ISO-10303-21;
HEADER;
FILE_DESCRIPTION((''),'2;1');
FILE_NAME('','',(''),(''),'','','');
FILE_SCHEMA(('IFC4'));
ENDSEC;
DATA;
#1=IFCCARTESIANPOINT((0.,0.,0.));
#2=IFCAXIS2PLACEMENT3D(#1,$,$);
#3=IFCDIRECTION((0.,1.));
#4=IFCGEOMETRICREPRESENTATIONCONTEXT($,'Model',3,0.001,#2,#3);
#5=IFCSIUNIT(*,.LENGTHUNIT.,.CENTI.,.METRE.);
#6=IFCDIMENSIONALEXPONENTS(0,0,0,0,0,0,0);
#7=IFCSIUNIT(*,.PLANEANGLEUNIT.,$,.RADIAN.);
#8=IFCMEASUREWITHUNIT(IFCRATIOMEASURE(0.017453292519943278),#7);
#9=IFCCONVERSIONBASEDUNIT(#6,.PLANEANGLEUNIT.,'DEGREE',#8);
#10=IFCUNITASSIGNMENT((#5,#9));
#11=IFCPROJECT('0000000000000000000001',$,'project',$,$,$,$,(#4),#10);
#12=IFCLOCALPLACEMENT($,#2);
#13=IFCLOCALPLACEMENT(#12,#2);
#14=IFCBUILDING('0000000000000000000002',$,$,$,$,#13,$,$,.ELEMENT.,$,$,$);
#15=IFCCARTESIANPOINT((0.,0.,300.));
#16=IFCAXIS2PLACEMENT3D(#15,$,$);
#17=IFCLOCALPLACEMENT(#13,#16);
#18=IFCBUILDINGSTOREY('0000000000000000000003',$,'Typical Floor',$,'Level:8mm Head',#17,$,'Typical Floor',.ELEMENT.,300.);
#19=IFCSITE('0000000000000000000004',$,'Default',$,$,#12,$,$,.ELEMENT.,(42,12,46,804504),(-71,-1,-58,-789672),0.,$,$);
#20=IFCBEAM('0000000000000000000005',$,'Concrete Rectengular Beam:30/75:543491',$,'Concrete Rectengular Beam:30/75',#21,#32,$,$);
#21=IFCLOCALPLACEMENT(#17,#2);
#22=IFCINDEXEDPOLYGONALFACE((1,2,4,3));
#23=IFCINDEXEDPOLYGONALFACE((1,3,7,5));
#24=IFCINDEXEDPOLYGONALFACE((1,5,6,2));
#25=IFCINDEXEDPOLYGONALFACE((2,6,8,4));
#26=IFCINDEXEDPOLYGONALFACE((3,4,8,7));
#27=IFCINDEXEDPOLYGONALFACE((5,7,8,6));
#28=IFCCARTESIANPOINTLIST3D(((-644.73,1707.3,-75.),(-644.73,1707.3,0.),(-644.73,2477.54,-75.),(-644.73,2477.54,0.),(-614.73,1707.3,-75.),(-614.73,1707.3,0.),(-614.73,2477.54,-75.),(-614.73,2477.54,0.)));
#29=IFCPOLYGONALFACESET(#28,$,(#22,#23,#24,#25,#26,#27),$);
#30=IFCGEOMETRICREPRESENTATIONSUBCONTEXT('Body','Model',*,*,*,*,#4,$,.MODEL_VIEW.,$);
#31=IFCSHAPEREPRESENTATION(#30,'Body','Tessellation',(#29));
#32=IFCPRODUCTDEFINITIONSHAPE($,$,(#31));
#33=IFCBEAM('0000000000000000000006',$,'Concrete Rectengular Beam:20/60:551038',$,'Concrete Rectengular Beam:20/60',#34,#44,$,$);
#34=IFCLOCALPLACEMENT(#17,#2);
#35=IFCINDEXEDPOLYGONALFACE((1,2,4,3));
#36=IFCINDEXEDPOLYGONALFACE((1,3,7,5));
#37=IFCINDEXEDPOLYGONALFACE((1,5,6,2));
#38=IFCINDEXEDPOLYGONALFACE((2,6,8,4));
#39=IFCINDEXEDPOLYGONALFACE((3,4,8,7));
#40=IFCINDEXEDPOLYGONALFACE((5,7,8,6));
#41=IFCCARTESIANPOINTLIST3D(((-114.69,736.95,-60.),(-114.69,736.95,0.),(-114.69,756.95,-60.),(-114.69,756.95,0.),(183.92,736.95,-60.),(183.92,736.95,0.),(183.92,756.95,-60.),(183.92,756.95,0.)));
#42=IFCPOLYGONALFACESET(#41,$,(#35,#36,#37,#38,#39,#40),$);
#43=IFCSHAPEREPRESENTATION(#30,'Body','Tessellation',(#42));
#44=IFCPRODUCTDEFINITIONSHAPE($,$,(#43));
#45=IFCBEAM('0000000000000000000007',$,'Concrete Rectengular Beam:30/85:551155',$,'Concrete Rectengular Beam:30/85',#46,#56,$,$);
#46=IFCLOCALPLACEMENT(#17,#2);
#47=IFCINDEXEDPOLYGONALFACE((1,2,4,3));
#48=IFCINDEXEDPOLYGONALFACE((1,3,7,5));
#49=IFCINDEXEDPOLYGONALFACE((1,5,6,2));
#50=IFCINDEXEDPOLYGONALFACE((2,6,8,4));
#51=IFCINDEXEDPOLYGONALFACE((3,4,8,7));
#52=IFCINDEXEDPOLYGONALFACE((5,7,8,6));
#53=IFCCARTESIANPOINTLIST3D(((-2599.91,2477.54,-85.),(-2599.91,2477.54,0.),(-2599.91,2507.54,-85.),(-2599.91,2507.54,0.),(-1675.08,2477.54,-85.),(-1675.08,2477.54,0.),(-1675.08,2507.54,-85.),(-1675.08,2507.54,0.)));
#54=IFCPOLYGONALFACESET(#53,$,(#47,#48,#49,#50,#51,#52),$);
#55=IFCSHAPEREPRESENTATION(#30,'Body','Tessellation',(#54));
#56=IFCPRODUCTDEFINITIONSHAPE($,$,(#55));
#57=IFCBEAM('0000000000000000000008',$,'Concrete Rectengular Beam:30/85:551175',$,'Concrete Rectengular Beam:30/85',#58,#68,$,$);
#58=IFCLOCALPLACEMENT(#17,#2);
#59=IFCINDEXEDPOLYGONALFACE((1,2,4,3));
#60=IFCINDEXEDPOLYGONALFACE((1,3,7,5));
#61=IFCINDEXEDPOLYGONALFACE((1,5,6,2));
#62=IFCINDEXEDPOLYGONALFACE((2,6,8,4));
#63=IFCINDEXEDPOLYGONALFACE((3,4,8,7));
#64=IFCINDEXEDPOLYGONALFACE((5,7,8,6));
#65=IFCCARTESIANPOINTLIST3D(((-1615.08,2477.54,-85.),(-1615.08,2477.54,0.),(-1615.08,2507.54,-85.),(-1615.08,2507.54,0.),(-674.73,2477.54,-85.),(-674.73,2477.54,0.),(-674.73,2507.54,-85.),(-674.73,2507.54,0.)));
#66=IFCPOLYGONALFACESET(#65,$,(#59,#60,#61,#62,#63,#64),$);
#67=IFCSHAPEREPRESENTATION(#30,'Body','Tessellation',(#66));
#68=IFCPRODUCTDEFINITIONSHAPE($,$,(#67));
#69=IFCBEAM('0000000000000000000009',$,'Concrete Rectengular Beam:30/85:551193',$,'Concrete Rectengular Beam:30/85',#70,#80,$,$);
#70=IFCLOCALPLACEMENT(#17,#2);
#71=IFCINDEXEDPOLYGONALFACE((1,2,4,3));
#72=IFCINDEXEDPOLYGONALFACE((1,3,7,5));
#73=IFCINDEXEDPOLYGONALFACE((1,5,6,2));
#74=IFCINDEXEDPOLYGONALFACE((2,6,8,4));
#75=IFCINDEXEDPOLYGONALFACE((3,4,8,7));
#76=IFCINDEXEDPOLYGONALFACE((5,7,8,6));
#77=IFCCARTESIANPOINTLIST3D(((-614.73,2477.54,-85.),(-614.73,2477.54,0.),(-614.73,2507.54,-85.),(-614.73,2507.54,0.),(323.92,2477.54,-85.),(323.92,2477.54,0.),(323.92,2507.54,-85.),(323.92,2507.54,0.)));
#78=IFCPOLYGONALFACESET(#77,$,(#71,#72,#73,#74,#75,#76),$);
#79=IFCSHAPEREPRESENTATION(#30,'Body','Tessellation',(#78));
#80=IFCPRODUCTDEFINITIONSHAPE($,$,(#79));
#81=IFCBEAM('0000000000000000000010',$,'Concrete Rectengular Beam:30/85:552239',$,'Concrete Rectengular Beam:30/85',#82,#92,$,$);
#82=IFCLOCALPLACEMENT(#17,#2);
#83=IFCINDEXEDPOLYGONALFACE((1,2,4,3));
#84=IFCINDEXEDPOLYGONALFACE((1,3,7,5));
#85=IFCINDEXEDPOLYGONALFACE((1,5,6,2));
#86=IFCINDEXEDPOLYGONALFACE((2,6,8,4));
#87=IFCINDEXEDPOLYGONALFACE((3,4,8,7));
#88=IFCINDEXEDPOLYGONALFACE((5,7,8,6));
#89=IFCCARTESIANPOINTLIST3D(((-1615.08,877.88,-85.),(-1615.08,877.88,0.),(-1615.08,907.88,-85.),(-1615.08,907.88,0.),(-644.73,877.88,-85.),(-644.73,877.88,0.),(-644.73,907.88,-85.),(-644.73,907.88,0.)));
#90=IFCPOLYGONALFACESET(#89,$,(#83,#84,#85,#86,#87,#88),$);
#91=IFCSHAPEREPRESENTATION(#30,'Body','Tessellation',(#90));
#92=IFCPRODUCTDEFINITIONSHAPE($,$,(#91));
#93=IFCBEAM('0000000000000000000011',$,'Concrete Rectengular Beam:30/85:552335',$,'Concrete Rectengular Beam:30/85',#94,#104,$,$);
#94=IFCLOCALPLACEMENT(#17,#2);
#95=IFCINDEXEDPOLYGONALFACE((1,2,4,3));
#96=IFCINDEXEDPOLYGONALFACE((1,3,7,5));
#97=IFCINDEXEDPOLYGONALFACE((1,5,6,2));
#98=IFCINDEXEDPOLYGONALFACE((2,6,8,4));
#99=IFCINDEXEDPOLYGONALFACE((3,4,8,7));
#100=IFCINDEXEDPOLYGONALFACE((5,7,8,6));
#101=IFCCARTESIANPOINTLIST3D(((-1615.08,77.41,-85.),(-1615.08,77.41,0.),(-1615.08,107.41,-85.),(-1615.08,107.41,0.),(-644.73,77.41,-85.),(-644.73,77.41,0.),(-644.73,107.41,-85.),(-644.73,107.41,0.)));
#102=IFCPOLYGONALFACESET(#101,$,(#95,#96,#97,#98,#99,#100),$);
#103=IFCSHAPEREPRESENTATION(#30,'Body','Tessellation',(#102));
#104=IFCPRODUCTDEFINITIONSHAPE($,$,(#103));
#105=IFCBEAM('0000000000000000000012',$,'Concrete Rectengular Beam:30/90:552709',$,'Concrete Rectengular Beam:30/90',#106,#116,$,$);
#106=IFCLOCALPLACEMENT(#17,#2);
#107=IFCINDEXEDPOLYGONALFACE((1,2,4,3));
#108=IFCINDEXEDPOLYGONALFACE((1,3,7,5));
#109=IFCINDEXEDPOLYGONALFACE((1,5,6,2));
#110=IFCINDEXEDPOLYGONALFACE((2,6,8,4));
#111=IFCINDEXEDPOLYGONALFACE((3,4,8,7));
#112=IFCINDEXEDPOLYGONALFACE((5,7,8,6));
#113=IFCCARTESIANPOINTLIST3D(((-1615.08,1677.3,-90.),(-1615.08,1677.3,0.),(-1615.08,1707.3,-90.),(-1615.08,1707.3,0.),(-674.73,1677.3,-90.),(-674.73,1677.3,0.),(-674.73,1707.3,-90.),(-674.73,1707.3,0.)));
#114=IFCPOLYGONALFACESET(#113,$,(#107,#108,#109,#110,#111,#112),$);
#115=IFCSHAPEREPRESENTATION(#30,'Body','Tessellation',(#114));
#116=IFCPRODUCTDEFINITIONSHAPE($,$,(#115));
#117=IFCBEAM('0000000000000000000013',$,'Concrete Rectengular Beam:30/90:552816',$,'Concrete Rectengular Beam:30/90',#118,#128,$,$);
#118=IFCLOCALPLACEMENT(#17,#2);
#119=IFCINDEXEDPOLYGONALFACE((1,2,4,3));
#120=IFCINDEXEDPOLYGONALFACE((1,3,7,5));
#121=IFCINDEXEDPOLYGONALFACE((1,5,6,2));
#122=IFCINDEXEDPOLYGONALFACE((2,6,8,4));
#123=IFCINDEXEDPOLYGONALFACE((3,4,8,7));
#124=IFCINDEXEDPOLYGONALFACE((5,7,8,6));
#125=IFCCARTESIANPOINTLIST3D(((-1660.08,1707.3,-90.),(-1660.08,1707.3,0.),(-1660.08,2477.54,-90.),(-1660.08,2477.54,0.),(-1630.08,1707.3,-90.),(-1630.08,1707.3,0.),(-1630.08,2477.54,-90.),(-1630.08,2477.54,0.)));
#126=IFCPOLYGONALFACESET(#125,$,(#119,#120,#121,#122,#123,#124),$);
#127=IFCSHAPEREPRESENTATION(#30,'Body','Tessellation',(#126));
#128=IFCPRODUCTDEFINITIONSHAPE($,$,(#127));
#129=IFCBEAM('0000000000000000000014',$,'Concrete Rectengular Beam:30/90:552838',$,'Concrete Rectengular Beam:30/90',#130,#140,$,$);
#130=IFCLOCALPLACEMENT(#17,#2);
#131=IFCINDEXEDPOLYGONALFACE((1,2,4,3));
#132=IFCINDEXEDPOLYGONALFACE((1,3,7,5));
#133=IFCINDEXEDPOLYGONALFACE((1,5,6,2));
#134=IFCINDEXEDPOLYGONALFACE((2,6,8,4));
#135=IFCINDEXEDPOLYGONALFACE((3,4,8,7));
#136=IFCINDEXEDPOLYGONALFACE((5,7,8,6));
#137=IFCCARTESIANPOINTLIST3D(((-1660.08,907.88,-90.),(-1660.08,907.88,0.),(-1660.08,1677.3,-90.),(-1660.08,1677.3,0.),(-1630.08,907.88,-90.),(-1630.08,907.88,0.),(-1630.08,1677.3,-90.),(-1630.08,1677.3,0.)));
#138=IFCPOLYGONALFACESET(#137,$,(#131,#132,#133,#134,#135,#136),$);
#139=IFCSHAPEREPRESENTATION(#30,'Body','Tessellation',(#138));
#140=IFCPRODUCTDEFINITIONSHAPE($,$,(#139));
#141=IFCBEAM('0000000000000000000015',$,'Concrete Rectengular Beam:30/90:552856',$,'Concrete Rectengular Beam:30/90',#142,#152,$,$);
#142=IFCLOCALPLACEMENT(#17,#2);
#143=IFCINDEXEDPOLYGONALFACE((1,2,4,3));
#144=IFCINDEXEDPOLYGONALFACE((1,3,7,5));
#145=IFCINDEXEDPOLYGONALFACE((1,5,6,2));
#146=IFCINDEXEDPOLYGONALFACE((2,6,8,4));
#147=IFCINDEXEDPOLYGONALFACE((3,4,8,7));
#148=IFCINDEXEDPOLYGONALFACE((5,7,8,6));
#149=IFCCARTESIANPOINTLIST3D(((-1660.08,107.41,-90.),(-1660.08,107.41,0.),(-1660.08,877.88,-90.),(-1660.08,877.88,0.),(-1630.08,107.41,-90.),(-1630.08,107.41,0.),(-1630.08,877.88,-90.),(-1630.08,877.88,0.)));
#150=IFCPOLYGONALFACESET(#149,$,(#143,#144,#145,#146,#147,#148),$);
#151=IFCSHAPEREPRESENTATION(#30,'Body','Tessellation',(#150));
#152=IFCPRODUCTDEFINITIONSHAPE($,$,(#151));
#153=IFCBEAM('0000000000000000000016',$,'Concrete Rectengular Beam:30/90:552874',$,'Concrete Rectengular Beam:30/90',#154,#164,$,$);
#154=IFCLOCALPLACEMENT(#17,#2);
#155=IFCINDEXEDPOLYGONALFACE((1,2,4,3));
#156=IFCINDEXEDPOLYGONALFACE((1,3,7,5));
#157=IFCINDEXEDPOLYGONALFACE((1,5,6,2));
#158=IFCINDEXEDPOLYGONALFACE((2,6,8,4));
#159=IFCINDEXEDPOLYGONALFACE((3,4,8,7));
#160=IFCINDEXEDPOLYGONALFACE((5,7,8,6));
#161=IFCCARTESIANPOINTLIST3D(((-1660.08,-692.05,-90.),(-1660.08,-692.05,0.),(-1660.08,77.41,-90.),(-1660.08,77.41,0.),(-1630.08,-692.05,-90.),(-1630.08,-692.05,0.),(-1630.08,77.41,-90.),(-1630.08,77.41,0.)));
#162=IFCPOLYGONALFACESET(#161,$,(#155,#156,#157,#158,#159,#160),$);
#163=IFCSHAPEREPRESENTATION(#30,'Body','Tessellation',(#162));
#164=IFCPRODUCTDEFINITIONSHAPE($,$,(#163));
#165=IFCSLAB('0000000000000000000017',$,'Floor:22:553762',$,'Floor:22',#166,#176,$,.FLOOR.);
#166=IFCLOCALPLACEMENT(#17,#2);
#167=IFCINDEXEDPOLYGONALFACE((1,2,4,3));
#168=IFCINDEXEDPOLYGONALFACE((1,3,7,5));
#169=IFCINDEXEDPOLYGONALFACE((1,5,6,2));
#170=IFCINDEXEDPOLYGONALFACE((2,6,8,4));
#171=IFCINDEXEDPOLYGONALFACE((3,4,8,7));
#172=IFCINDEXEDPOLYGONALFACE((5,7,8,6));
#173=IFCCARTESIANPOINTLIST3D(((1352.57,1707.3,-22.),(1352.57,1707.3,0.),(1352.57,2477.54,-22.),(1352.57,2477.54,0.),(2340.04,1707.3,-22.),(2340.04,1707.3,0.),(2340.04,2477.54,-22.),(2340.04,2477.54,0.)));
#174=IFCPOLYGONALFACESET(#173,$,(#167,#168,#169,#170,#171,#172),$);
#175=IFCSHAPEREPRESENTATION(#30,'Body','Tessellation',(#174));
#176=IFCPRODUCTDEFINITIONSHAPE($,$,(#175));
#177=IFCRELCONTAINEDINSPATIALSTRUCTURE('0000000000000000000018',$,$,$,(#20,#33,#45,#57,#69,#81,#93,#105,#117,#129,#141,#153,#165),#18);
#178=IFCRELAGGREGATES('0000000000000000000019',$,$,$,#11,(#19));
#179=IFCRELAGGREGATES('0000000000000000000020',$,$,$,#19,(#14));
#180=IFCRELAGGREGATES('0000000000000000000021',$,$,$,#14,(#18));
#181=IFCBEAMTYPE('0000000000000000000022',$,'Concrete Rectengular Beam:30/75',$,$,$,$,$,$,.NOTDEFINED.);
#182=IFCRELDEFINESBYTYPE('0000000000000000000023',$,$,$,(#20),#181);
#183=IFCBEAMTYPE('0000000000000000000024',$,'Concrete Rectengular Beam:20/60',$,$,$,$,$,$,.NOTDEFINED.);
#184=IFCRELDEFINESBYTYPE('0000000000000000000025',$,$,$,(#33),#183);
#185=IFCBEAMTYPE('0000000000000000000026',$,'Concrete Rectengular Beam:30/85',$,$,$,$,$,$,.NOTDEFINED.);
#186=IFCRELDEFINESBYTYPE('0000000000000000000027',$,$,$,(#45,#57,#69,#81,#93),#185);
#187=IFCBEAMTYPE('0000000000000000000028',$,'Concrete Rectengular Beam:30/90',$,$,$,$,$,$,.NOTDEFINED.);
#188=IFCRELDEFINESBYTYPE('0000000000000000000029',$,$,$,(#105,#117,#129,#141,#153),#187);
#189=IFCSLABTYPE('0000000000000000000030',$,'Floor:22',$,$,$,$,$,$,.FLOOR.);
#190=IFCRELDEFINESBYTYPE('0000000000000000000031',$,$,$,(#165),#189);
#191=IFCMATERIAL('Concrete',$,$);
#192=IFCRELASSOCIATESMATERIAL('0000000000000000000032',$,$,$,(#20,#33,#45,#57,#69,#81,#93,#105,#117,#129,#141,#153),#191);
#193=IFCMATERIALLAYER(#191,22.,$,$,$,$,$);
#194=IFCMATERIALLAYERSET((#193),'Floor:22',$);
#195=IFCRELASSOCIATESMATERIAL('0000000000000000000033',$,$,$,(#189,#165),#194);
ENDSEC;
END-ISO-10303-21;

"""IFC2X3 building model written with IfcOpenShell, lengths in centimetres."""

from ifc_helpers import new_model, entity, si_unit, converted_unit, direction, frame, frame_2d, origin, origin_2d_with_axis, place, context, subcontext, project, spatial, rectangle, extrude, material, layer, layer_set, layer_usage, type_object, element, save


model = new_model("IFC2X3")

# Units and contexts
model_context = context("Model", 3, precision=0.001, world=origin(), true_north=direction((0.0, 1.0)))
body_context = subcontext(model_context, "Body", "Model", "MODEL_VIEW")
ifc_project = project(units=[si_unit("LENGTHUNIT", "METRE", prefix="CENTI"), converted_unit("PLANEANGLEUNIT", "DEGREE", entity("IfcRatioMeasure", 0.017453292519943278), si_unit("PLANEANGLEUNIT", "RADIAN"), dimensions=[0, 0, 0, 0, 0, 0, 0])], contexts=[model_context])

# Site, building, storey
site_placement = place(None, origin())
site = spatial("IfcSite", under=ifc_project, at=site_placement, Name="Default", CompositionType="ELEMENT", RefLatitude=(42, 12, 46, 804504), RefLongitude=(-71, -1, -58, -789672), RefElevation=0.0)
building_placement = place(site_placement, origin())
building = spatial("IfcBuilding", under=site, at=building_placement, CompositionType="ELEMENT")
storey_placement = place(building_placement, frame((0.0, 0.0, 300.0)))
storey = spatial("IfcBuildingStorey", under=building, at=storey_placement, Name="Typical Floor", ObjectType="Level:8mm Head", LongName="Typical Floor", CompositionType="ELEMENT", Elevation=300.0)

# Beams
ifc_material = material(Name="Concrete")
beam_type_1 = type_object("IfcBeamType", Name="Concrete Rectengular Beam:30/75", PredefinedType="NOTDEFINED")
beam_1_placement = place(storey_placement, frame((-629.73, 2492.54, 0.0), z_axis=(0.0, 0.0, 1.0), x_axis=(0.0, -1.0, 0.0)))
element("IfcBeam", 1, at=beam_1_placement, inside=storey, type_object=beam_type_1, material=ifc_material, Name="Concrete Rectengular Beam:30/75:543491", ObjectType="Concrete Rectengular Beam:30/75", context=body_context, shape_type="SweptSolid", body=[
    extrude(rectangle(XDim=75.0, YDim=30.0, at=frame_2d((0.0, 0.0), x_axis=(1.0, 0.0))), frame((15.0, 0.0, -37.5), z_axis=(1.0, 0.0, 0.0), x_axis=(0.0, 0.0, -1.0)), (0.0, 0.0, 1.0), 770.24),
])
beam_type_2 = type_object("IfcBeamType", Name="Concrete Rectengular Beam:20/60", PredefinedType="NOTDEFINED")
beam_2_placement = place(storey_placement, frame((-124.69, 746.95, 0.0)))
element("IfcBeam", 2, at=beam_2_placement, inside=storey, type_object=beam_type_2, material=ifc_material, Name="Concrete Rectengular Beam:20/60:551038", ObjectType="Concrete Rectengular Beam:20/60", context=body_context, shape_type="SweptSolid", body=[
    extrude(rectangle(XDim=60.0, YDim=20.0, at=frame_2d((0.0, 0.0), x_axis=(1.0, 0.0))), frame((10.0, 0.0, -30.0), z_axis=(1.0, 0.0, 0.0), x_axis=(0.0, 0.0, -1.0)), (0.0, 0.0, 1.0), 298.61),
])
beam_type_3 = type_object("IfcBeamType", Name="Concrete Rectengular Beam:30/85", PredefinedType="NOTDEFINED")
beam_3_placement = place(storey_placement, frame((-2629.91, 2492.54, 0.0)))
element("IfcBeam", 3, at=beam_3_placement, inside=storey, type_object=beam_type_3, material=ifc_material, Name="Concrete Rectengular Beam:30/85:551155", ObjectType="Concrete Rectengular Beam:30/85", context=body_context, shape_type="SweptSolid", body=[
    extrude(rectangle(XDim=85.0, YDim=30.0, at=frame_2d((0.0, 0.0), x_axis=(1.0, 0.0))), frame((30.0, 0.0, -42.5), z_axis=(1.0, 0.0, 0.0), x_axis=(0.0, 0.0, -1.0)), (0.0, 0.0, 1.0), 924.83),
])
beam_4_placement = place(storey_placement, frame((-1645.08, 2492.54, 0.0)))
element("IfcBeam", 4, at=beam_4_placement, inside=storey, type_object=beam_type_3, material=ifc_material, Name="Concrete Rectengular Beam:30/85:551175", ObjectType="Concrete Rectengular Beam:30/85", context=body_context, shape_type="SweptSolid", body=[
    extrude(rectangle(XDim=85.0, YDim=30.0, at=frame_2d((0.0, 0.0), x_axis=(1.0, 0.0))), frame((30.0, 0.0, -42.5), z_axis=(1.0, 0.0, 0.0), x_axis=(0.0, 0.0, -1.0)), (0.0, 0.0, 1.0), 940.35),
])
beam_5_placement = place(storey_placement, frame((-644.73, 2492.54, 0.0)))
element("IfcBeam", 5, at=beam_5_placement, inside=storey, type_object=beam_type_3, material=ifc_material, Name="Concrete Rectengular Beam:30/85:551193", ObjectType="Concrete Rectengular Beam:30/85", context=body_context, shape_type="SweptSolid", body=[
    extrude(rectangle(XDim=85.0, YDim=30.0, at=frame_2d((0.0, 0.0), x_axis=(1.0, 0.0))), frame((30.0, 0.0, -42.5), z_axis=(1.0, 0.0, 0.0), x_axis=(0.0, 0.0, -1.0)), (0.0, 0.0, 1.0), 938.65),
])
beam_6_placement = place(storey_placement, frame((-1645.08, 892.88, 0.0)))
element("IfcBeam", 6, at=beam_6_placement, inside=storey, type_object=beam_type_3, material=ifc_material, Name="Concrete Rectengular Beam:30/85:552239", ObjectType="Concrete Rectengular Beam:30/85", context=body_context, shape_type="SweptSolid", body=[
    extrude(rectangle(XDim=85.0, YDim=30.0, at=frame_2d((0.0, 0.0), x_axis=(1.0, 0.0))), frame((30.0, 0.0, -42.5), z_axis=(1.0, 0.0, 0.0), x_axis=(0.0, 0.0, -1.0)), (0.0, 0.0, 1.0), 970.35),
])
beam_7_placement = place(storey_placement, frame((-1645.08, 92.41, 0.0)))
element("IfcBeam", 7, at=beam_7_placement, inside=storey, type_object=beam_type_3, material=ifc_material, Name="Concrete Rectengular Beam:30/85:552335", ObjectType="Concrete Rectengular Beam:30/85", context=body_context, shape_type="SweptSolid", body=[
    extrude(rectangle(XDim=85.0, YDim=30.0, at=frame_2d((0.0, 0.0), x_axis=(1.0, 0.0))), frame((30.0, 0.0, -42.5), z_axis=(1.0, 0.0, 0.0), x_axis=(0.0, 0.0, -1.0)), (0.0, 0.0, 1.0), 970.35),
])
beam_type_4 = type_object("IfcBeamType", Name="Concrete Rectengular Beam:30/90", PredefinedType="NOTDEFINED")
beam_8_placement = place(storey_placement, frame((-644.73, 1692.3, 0.0), z_axis=(0.0, 0.0, 1.0), x_axis=(-1.0, 0.0, 0.0)))
element("IfcBeam", 8, at=beam_8_placement, inside=storey, type_object=beam_type_4, material=ifc_material, Name="Concrete Rectengular Beam:30/90:552709", ObjectType="Concrete Rectengular Beam:30/90", context=body_context, shape_type="SweptSolid", body=[
    extrude(rectangle(XDim=90.0, YDim=30.0, at=frame_2d((0.0, 0.0), x_axis=(1.0, 0.0))), frame((30.0, 0.0, -45.0), z_axis=(1.0, 0.0, 0.0), x_axis=(0.0, 0.0, -1.0)), (0.0, 0.0, 1.0), 940.35),
])
beam_9_placement = place(storey_placement, frame((-1645.08, 2492.54, 0.0), z_axis=(0.0, 0.0, 1.0), x_axis=(0.0, -1.0, 0.0)))
element("IfcBeam", 9, at=beam_9_placement, inside=storey, type_object=beam_type_4, material=ifc_material, Name="Concrete Rectengular Beam:30/90:552816", ObjectType="Concrete Rectengular Beam:30/90", context=body_context, shape_type="SweptSolid", body=[
    extrude(rectangle(XDim=90.0, YDim=30.0, at=frame_2d((0.0, 0.0), x_axis=(1.0, 0.0))), frame((15.0, 0.0, -45.0), z_axis=(1.0, 0.0, 0.0), x_axis=(0.0, 0.0, -1.0)), (0.0, 0.0, 1.0), 770.24),
])
beam_10_placement = place(storey_placement, frame((-1645.08, 1692.3, 0.0), z_axis=(0.0, 0.0, 1.0), x_axis=(0.0, -1.0, 0.0)))
element("IfcBeam", 10, at=beam_10_placement, inside=storey, type_object=beam_type_4, material=ifc_material, Name="Concrete Rectengular Beam:30/90:552838", ObjectType="Concrete Rectengular Beam:30/90", context=body_context, shape_type="SweptSolid", body=[
    extrude(rectangle(XDim=90.0, YDim=30.0, at=frame_2d((0.0, 0.0), x_axis=(1.0, 0.0))), frame((15.0, 0.0, -45.0), z_axis=(1.0, 0.0, 0.0), x_axis=(0.0, 0.0, -1.0)), (0.0, 0.0, 1.0), 769.42),
])
beam_11_placement = place(storey_placement, frame((-1645.08, 892.88, 0.0), z_axis=(0.0, 0.0, 1.0), x_axis=(0.0, -1.0, 0.0)))
element("IfcBeam", 11, at=beam_11_placement, inside=storey, type_object=beam_type_4, material=ifc_material, Name="Concrete Rectengular Beam:30/90:552856", ObjectType="Concrete Rectengular Beam:30/90", context=body_context, shape_type="SweptSolid", body=[
    extrude(rectangle(XDim=90.0, YDim=30.0, at=frame_2d((0.0, 0.0), x_axis=(1.0, 0.0))), frame((15.0, 0.0, -45.0), z_axis=(1.0, 0.0, 0.0), x_axis=(0.0, 0.0, -1.0)), (0.0, 0.0, 1.0), 770.47),
])
beam_12_placement = place(storey_placement, frame((-1645.08, 92.41, 0.0), z_axis=(0.0, 0.0, 1.0), x_axis=(0.0, -1.0, 0.0)))
element("IfcBeam", 12, at=beam_12_placement, inside=storey, type_object=beam_type_4, material=ifc_material, Name="Concrete Rectengular Beam:30/90:552874", ObjectType="Concrete Rectengular Beam:30/90", context=body_context, shape_type="SweptSolid", body=[
    extrude(rectangle(XDim=90.0, YDim=30.0, at=frame_2d((0.0, 0.0), x_axis=(1.0, 0.0))), frame((15.0, 0.0, -45.0), z_axis=(1.0, 0.0, 0.0), x_axis=(0.0, 0.0, -1.0)), (0.0, 0.0, 1.0), 769.46),
])

# Slab
ifc_layer = layer(ifc_material, 22.0)
ifc_layer_set = layer_set([ifc_layer], Name="Floor:22")
ifc_layer_usage_1 = layer_usage(ifc_layer_set, "AXIS3", "POSITIVE", 0.0)
slab_type_1 = type_object("IfcSlabType", Name="Floor:22", PredefinedType="FLOOR", material=ifc_layer_set)
slab_1_placement = place(storey_placement, origin())
element("IfcSlab", 13, at=slab_1_placement, inside=storey, type_object=slab_type_1, material=ifc_layer_usage_1, Name="Floor:22:553762", ObjectType="Floor:22", PredefinedType="FLOOR", context=body_context, shape_type="SweptSolid", body=[
    extrude(rectangle(XDim=770.24, YDim=987.46, at=origin_2d_with_axis()), frame((1846.3, 2092.42, 0.0), z_axis=(0.0, 0.0, -1.0), x_axis=(0.0, 1.0, 0.0)), (0.0, 0.0, 1.0), 22.0),
])

save(model, "model.ifc")
